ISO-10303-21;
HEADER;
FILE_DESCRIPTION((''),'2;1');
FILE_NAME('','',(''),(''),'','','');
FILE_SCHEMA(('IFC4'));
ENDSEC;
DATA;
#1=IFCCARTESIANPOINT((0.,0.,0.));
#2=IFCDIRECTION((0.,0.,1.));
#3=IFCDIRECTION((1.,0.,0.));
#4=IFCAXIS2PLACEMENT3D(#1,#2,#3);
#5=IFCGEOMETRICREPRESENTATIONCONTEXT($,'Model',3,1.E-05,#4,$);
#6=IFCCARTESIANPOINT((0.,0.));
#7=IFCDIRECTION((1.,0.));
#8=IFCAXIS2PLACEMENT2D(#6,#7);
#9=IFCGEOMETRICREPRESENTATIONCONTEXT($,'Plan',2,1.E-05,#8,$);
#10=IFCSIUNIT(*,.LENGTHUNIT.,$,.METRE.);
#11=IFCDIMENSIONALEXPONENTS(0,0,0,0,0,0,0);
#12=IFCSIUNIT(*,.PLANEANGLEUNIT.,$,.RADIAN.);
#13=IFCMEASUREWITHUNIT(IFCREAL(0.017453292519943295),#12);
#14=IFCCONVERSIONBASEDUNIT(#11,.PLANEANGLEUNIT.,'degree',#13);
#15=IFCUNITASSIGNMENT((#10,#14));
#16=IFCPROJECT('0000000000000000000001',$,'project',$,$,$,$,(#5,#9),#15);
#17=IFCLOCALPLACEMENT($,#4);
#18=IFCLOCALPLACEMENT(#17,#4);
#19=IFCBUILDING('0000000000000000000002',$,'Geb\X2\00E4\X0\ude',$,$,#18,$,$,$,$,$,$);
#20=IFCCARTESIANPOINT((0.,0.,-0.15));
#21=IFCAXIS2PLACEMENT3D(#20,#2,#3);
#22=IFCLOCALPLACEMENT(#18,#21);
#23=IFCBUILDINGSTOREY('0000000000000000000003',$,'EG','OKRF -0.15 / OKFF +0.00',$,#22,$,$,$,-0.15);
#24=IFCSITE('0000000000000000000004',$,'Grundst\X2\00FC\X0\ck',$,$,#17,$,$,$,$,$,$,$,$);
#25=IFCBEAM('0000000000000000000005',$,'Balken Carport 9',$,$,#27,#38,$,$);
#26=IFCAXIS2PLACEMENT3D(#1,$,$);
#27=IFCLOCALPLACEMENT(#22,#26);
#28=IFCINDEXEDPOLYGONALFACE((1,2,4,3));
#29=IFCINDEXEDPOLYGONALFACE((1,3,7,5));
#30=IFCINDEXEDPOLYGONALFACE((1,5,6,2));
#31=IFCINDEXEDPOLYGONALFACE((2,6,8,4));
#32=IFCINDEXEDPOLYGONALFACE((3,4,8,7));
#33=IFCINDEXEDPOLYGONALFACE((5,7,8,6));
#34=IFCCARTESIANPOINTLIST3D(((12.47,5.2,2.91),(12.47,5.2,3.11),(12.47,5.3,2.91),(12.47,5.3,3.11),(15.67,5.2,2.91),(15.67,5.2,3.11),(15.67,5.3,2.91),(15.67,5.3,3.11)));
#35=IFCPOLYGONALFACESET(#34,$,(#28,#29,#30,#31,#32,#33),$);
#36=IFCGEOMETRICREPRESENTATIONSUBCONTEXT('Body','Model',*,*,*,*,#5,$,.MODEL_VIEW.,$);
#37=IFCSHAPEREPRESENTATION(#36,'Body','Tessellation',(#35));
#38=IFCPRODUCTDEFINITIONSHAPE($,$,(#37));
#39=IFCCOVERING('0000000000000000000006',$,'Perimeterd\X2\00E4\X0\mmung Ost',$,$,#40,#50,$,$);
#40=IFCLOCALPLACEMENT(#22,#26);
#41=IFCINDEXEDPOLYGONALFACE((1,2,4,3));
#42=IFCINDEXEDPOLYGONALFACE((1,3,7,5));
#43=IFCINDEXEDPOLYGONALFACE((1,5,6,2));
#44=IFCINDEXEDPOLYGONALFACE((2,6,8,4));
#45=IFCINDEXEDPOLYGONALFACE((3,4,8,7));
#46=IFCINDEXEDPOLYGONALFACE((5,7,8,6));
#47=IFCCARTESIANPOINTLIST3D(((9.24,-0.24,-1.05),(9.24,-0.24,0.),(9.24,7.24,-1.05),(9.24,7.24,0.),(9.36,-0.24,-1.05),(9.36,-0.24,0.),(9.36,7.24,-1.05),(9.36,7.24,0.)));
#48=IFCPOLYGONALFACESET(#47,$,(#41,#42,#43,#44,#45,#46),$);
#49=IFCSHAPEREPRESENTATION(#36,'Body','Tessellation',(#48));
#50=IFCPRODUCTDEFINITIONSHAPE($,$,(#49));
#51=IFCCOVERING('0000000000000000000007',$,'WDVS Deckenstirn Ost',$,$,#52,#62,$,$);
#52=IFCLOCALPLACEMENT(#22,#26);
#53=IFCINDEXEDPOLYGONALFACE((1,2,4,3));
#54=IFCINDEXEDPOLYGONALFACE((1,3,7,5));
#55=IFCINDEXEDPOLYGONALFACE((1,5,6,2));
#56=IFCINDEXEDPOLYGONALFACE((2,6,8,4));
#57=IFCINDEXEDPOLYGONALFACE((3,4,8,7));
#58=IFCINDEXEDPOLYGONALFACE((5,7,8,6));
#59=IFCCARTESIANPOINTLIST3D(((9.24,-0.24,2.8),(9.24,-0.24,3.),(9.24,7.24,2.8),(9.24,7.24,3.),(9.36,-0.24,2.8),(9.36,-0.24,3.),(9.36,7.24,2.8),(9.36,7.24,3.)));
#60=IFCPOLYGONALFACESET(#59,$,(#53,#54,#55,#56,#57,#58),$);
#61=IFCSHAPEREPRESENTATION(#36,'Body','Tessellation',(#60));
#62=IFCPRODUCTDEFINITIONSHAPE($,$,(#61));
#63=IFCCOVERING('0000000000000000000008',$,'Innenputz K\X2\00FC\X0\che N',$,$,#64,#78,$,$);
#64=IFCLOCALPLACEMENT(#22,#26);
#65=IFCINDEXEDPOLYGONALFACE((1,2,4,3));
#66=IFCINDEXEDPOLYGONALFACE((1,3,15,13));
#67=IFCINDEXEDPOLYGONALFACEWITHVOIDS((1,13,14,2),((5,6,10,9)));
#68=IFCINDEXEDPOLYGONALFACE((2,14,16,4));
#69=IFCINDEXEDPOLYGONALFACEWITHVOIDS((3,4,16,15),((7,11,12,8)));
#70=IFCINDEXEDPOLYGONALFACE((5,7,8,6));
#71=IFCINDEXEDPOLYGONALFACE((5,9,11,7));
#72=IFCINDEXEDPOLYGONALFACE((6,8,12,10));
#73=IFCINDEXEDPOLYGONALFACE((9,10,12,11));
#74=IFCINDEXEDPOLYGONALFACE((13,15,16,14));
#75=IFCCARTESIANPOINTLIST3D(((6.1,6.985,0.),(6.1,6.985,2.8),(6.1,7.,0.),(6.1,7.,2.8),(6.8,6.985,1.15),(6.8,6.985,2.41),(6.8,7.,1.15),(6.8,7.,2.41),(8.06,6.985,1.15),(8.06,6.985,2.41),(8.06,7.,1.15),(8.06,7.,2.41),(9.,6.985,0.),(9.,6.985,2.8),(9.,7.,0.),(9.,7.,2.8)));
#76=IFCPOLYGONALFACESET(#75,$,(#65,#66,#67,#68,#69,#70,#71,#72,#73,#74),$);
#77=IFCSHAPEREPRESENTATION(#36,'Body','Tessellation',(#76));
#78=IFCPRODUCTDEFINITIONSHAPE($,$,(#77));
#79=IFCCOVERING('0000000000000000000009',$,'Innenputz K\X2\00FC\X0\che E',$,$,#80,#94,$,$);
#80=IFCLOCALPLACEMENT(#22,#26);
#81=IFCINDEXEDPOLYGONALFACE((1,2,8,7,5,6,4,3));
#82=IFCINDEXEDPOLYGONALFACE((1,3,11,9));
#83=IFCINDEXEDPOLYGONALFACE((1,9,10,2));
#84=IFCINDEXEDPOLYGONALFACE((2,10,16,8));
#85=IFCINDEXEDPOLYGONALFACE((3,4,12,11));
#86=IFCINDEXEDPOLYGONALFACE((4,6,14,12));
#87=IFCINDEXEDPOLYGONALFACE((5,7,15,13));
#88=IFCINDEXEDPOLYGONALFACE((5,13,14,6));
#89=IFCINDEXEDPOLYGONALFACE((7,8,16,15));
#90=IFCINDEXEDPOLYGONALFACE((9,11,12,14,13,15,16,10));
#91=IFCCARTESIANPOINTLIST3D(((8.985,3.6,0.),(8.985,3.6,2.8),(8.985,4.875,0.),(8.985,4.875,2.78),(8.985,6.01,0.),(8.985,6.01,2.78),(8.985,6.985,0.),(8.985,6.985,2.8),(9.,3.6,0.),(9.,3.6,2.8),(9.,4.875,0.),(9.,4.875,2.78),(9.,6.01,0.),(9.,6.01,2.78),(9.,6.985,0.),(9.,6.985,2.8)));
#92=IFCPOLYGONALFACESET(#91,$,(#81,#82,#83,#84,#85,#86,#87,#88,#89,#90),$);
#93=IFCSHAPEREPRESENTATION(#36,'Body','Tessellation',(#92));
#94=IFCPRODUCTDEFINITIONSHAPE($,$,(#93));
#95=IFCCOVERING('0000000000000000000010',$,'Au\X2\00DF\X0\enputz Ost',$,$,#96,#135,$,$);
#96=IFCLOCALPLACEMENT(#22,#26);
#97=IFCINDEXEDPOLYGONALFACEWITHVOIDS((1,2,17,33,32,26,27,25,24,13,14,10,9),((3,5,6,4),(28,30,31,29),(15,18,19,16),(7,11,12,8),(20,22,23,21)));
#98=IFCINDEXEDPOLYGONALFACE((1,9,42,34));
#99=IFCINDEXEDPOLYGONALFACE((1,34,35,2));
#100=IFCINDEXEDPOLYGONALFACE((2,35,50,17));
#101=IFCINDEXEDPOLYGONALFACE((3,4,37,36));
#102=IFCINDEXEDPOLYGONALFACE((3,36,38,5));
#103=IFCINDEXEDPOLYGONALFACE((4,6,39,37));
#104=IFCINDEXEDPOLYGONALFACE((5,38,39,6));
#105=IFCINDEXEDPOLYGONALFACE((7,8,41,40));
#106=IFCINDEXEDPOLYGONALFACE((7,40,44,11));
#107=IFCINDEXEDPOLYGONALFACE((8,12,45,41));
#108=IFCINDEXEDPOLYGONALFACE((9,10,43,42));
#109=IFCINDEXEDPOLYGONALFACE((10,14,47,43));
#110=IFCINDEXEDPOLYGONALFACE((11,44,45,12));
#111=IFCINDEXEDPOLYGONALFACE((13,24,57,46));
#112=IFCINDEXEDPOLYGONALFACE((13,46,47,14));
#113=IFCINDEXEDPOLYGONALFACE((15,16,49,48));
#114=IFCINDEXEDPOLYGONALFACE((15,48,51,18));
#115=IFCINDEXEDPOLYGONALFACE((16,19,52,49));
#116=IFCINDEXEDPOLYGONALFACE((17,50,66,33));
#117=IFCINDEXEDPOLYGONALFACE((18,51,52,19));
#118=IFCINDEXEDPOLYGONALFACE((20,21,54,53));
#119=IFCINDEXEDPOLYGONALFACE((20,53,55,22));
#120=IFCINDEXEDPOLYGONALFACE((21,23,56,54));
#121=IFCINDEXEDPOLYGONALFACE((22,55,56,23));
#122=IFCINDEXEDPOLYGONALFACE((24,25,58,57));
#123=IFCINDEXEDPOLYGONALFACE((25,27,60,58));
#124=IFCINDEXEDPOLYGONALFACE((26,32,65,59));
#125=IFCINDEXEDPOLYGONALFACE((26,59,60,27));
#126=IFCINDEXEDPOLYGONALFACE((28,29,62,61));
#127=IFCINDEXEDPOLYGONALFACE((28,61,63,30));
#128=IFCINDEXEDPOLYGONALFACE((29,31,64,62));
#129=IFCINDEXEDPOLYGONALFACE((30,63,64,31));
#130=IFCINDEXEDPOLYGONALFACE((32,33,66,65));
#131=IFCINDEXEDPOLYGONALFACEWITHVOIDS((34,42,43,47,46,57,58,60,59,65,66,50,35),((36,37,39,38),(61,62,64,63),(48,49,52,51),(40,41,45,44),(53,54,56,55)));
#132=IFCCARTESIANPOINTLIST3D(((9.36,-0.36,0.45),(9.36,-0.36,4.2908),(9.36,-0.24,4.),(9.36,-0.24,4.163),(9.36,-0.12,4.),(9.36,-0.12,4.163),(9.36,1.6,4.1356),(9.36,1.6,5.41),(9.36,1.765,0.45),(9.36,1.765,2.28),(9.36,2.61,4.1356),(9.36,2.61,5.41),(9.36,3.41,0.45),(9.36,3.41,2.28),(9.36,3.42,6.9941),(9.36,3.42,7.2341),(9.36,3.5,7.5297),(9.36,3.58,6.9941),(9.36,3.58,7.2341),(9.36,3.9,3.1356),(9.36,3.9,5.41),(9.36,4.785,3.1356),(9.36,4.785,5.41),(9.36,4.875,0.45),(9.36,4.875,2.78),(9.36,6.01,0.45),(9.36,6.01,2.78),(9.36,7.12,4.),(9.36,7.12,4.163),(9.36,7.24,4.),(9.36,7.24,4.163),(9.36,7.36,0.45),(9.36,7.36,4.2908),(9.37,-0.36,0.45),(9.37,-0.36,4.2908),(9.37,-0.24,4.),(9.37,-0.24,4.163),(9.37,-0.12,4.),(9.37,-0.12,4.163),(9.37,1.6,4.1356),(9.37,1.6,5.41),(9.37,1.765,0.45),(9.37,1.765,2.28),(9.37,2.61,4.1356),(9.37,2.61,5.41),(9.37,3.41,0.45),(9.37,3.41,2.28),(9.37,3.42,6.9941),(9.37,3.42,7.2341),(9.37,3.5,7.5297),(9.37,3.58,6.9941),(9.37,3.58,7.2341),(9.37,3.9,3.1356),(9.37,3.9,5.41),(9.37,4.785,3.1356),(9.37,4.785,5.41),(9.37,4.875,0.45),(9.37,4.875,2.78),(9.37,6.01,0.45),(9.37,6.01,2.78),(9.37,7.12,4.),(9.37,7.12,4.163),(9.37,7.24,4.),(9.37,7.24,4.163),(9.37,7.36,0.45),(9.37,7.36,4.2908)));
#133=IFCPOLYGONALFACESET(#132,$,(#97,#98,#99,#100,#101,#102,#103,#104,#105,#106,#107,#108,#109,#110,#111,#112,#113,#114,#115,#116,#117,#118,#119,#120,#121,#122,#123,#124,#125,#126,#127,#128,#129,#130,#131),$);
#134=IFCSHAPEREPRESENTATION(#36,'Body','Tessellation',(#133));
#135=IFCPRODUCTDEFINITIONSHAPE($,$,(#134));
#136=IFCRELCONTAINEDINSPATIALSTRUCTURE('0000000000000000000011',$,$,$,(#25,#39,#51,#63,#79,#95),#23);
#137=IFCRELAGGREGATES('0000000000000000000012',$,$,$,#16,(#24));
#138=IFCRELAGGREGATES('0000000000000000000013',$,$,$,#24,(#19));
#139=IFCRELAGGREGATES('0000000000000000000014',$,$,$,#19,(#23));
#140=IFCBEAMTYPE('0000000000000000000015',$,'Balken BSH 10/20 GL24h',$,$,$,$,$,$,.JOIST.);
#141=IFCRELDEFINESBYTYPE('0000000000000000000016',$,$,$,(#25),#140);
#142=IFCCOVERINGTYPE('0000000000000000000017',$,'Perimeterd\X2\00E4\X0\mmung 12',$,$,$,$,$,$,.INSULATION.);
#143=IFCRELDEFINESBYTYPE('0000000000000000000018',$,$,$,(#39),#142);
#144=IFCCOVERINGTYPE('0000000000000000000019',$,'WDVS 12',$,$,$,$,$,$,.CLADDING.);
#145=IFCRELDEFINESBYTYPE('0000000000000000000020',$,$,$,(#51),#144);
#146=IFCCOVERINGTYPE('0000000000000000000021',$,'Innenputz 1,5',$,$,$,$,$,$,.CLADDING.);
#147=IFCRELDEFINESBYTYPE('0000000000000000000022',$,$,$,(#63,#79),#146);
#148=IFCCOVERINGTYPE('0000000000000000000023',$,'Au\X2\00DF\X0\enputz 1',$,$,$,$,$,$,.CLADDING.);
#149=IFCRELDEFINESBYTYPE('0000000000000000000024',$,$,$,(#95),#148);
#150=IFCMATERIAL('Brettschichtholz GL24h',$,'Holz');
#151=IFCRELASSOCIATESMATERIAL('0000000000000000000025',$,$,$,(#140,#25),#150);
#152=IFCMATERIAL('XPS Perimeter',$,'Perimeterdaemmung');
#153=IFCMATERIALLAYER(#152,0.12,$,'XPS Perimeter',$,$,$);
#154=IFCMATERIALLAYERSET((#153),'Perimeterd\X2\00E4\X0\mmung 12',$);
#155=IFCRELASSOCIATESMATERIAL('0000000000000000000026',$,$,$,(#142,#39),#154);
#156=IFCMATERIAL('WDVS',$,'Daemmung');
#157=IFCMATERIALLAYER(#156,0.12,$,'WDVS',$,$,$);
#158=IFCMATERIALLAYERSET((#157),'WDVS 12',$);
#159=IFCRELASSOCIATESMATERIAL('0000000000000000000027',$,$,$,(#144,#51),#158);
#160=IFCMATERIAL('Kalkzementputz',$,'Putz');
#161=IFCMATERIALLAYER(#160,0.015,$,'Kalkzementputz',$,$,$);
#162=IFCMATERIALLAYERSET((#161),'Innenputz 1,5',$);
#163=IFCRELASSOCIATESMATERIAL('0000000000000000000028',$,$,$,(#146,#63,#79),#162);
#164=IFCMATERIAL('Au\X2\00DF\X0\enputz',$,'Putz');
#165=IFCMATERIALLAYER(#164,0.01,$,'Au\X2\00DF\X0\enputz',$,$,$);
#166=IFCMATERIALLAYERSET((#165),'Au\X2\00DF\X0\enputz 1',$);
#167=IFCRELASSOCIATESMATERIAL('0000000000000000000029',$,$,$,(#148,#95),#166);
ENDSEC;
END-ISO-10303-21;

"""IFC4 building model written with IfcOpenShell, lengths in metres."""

from ifc_helpers import new_model, entity, si_unit, converted_unit, frame, origin_with_axes, origin_2d_with_axis, place, context, subcontext, project, spatial, indexed_curve, rectangle, outline, extrude, clip, halfspace, material, layer, layer_set, layer_usage, material_profile, profile_set, profile_usage, type_object, element, save


model = new_model("IFC4")

# Units and contexts
model_context = context("Model", 3, precision=1e-05, world=origin_with_axes())
plan_context = context("Plan", 2, precision=1e-05, world=origin_2d_with_axis())
body_context = subcontext(model_context, "Body", "Model", "MODEL_VIEW")
ifc_project = project(units=[si_unit("LENGTHUNIT", "METRE"), converted_unit("PLANEANGLEUNIT", "degree", entity("IfcReal", 0.017453292519943295), si_unit("PLANEANGLEUNIT", "RADIAN"), dimensions=[0, 0, 0, 0, 0, 0, 0])], contexts=[model_context, plan_context])

# Site, building, storey
site_placement = place(None, origin_with_axes())
site = spatial("IfcSite", under=ifc_project, at=site_placement, Name="Grundstück")
building_placement = place(site_placement, origin_with_axes())
building = spatial("IfcBuilding", under=site, at=building_placement, Name="Gebäude")
storey_placement = place(building_placement, frame((0.0, 0.0, -0.15), z_axis=(0.0, 0.0, 1.0), x_axis=(1.0, 0.0, 0.0)))
storey = spatial("IfcBuildingStorey", under=building, at=storey_placement, Name="EG", Description="OKRF -0.15 / OKFF +0.00", Elevation=-0.15)

# Beam
ifc_material_1 = material(Name="Brettschichtholz GL24h", Category="Holz")
ifc_material_profile_1 = material_profile(ifc_material_1, rectangle(XDim=0.1, YDim=0.2))
ifc_profile_set_1 = profile_set([ifc_material_profile_1], Name="Balken BSH 10/20 GL24h")
ifc_profile_usage_1 = profile_usage(ifc_profile_set_1)
beam_type_1 = type_object("IfcBeamType", Name="Balken BSH 10/20 GL24h", PredefinedType="JOIST", material=ifc_profile_set_1)
beam_1_placement = place(storey_placement, frame((12.47, 5.25, 3.01), z_axis=(1.0, 0.0, 0.0), x_axis=(0.0, 1.0, 0.0)))
element("IfcBeam", 1, at=beam_1_placement, inside=storey, type_object=beam_type_1, material=ifc_profile_usage_1, Name="Balken Carport 9", context=body_context, shape_type="SweptSolid", body=[
    extrude(rectangle(XDim=0.1, YDim=0.2), origin_with_axes(), (0.0, 0.0, 1.0), 3.2),
])

# Coverings
ifc_material_2 = material(Name="XPS Perimeter", Category="Perimeterdaemmung")
ifc_layer_1 = layer(ifc_material_2, 0.12, Name="XPS Perimeter")
ifc_layer_set_1 = layer_set([ifc_layer_1], Name="Perimeterdämmung 12")
ifc_layer_usage_1 = layer_usage(ifc_layer_set_1, "AXIS2", "POSITIVE", 0.0)
covering_type_1 = type_object("IfcCoveringType", Name="Perimeterdämmung 12", PredefinedType="INSULATION", material=ifc_layer_set_1)
covering_1_placement = place(storey_placement, frame((9.24, 7.24, -1.05), z_axis=(0.0, 0.0, 1.0), x_axis=(0.0, -1.0, 0.0)))
element("IfcCovering", 2, at=covering_1_placement, inside=storey, type_object=covering_type_1, material=ifc_layer_usage_1, Name="Perimeterdämmung Ost", context=body_context, shape_type="SweptSolid", body=[
    extrude(outline(indexed_curve([(0.0, 0.0), (0.0, 0.12), (7.48, 0.12), (7.48, 0.0), (0.0, 0.0)], self_intersect=False)), origin_with_axes(), (0.0, 0.0, 1.0), 1.05),
])
ifc_material_3 = material(Name="WDVS", Category="Daemmung")
ifc_layer_2 = layer(ifc_material_3, 0.12, Name="WDVS")
ifc_layer_set_2 = layer_set([ifc_layer_2], Name="WDVS 12")
ifc_layer_usage_2 = layer_usage(ifc_layer_set_2, "AXIS2", "POSITIVE", 0.0)
covering_type_2 = type_object("IfcCoveringType", Name="WDVS 12", PredefinedType="CLADDING", material=ifc_layer_set_2)
covering_2_placement = place(storey_placement, frame((9.24, 7.24, 2.8), z_axis=(0.0, 0.0, 1.0), x_axis=(0.0, -1.0, 0.0)))
element("IfcCovering", 3, at=covering_2_placement, inside=storey, type_object=covering_type_2, material=ifc_layer_usage_2, Name="WDVS Deckenstirn Ost", context=body_context, shape_type="SweptSolid", body=[
    extrude(outline(indexed_curve([(0.0, 0.0), (0.0, 0.12), (7.48, 0.12), (7.48, 0.0), (0.0, 0.0)], self_intersect=False)), origin_with_axes(), (0.0, 0.0, 1.0), 0.2),
])
ifc_material_4 = material(Name="Kalkzementputz", Category="Putz")
ifc_layer_3 = layer(ifc_material_4, 0.015, Name="Kalkzementputz")
ifc_layer_set_3 = layer_set([ifc_layer_3], Name="Innenputz 1,5")
covering_type_3 = type_object("IfcCoveringType", Name="Innenputz 1,5", PredefinedType="CLADDING", material=ifc_layer_set_3)

# Coverings, openings
ifc_layer_usage_3 = layer_usage(ifc_layer_set_3, "AXIS2", "POSITIVE", 0.0)
covering_3_placement = place(storey_placement, frame((9.0, 7.0, 0.0), z_axis=(0.0, 0.0, 1.0), x_axis=(-1.0, 0.0, 0.0)))
covering_3 = element("IfcCovering", 4, at=covering_3_placement, inside=storey, type_object=covering_type_3, material=ifc_layer_usage_3, Name="Innenputz Küche N", context=body_context, shape_type="SweptSolid", body=[
    extrude(outline(indexed_curve([(0.0, 0.0), (0.0, 0.015), (2.9, 0.015), (2.9, 0.0), (0.0, 0.0)], self_intersect=False)), origin_with_axes(), (0.0, 0.0, 1.0), 2.8),
])
opening_1_placement = place(covering_3_placement, frame((0.94, -0.05, 1.15), z_axis=(0.0, 0.0, 1.0), x_axis=(1.0, 0.0, 0.0)))
element("IfcOpeningElement", 5, at=opening_1_placement, cuts=covering_3, context=body_context, shape_type="SweptSolid", body=[
    extrude(outline(indexed_curve([(0.0, 0.0), (0.0, 0.115), (1.26, 0.115), (1.26, 0.0), (0.0, 0.0)], self_intersect=False)), origin_with_axes(), (0.0, 0.0, 1.0), 1.26),
])
ifc_layer_usage_4 = layer_usage(ifc_layer_set_3, "AXIS2", "POSITIVE", 0.0)
covering_4_placement = place(storey_placement, frame((9.0, 3.6, 0.0), z_axis=(0.0, 0.0, 1.0), x_axis=(0.0, 1.0, 0.0)))
covering_4 = element("IfcCovering", 6, at=covering_4_placement, inside=storey, type_object=covering_type_3, material=ifc_layer_usage_4, Name="Innenputz Küche E", context=body_context, shape_type="SweptSolid", body=[
    extrude(outline(indexed_curve([(0.0, 0.0), (0.0, 0.015), (3.385, 0.015), (3.385, 0.0), (0.0, 0.0)], self_intersect=False)), origin_with_axes(), (0.0, 0.0, 1.0), 2.8),
])
opening_2_placement = place(covering_4_placement, frame((1.275, -0.05, 0.0), z_axis=(0.0, 0.0, 1.0), x_axis=(1.0, 0.0, 0.0)))
element("IfcOpeningElement", 7, at=opening_2_placement, cuts=covering_4, context=body_context, shape_type="SweptSolid", body=[
    extrude(outline(indexed_curve([(0.0, 0.0), (0.0, 0.115), (1.135, 0.115), (1.135, 0.0), (0.0, 0.0)], self_intersect=False)), origin_with_axes(), (0.0, 0.0, 1.0), 2.78),
])

# Shared definitions
ifc_material_5 = material(Name="Außenputz", Category="Putz")
ifc_layer_4 = layer(ifc_material_5, 0.01, Name="Außenputz")
ifc_layer_set_4 = layer_set([ifc_layer_4], Name="Außenputz 1")
covering_type_4 = type_object("IfcCoveringType", Name="Außenputz 1", PredefinedType="CLADDING", material=ifc_layer_set_4)

# Covering, openings
ifc_layer_usage_5 = layer_usage(ifc_layer_set_4, "AXIS2", "POSITIVE", 0.0)
covering_5_placement = place(storey_placement, frame((9.36, 7.36, 0.45), z_axis=(0.0, 0.0, 1.0), x_axis=(0.0, -1.0, 0.0)))
covering_5 = element("IfcCovering", 8, at=covering_5_placement, inside=storey, type_object=covering_type_4, material=ifc_layer_usage_5, Name="Außenputz Ost", context=body_context, shape_type="Clipping", body=[
    clip(clip(extrude(outline(indexed_curve([(0.0, 0.0), (0.0, 0.01), (7.72, 0.01), (7.72, 0.0), (0.0, 0.0)], self_intersect=False)), origin_with_axes(), (0.0, 0.0, 1.0), 7.4797), halfspace(frame((7.6, -9.36, 3.9414), z_axis=(0.642788, 0.0, 0.766044), x_axis=(0.0, -1.0, 0.0)), False)), halfspace(frame((0.12, -9.36, 3.9414), z_axis=(-0.642788, 0.0, 0.766044), x_axis=(0.0, 1.0, 0.0)), False)),
])
opening_3_placement = place(covering_5_placement, frame((1.35, -0.05, 0.0), z_axis=(0.0, 0.0, 1.0), x_axis=(1.0, 0.0, 0.0)))
element("IfcOpeningElement", 9, at=opening_3_placement, cuts=covering_5, context=body_context, shape_type="SweptSolid", body=[
    extrude(outline(indexed_curve([(0.0, 0.0), (0.0, 0.11), (1.135, 0.11), (1.135, 0.0), (0.0, 0.0)], self_intersect=False)), origin_with_axes(), (0.0, 0.0, 1.0), 2.33),
])
opening_4_placement = place(covering_5_placement, frame((3.95, -0.05, 0.0), z_axis=(0.0, 0.0, 1.0), x_axis=(1.0, 0.0, 0.0)))
element("IfcOpeningElement", 10, at=opening_4_placement, cuts=covering_5, context=body_context, shape_type="SweptSolid", body=[
    extrude(outline(indexed_curve([(0.0, 0.0), (0.0, 0.11), (1.645, 0.11), (1.645, 0.0), (0.0, 0.0)], self_intersect=False)), origin_with_axes(), (0.0, 0.0, 1.0), 1.83),
])
opening_5_placement = place(covering_5_placement, frame((4.75, -0.05, 3.6856), z_axis=(0.0, 0.0, 1.0), x_axis=(1.0, 0.0, 0.0)))
element("IfcOpeningElement", 11, at=opening_5_placement, cuts=covering_5, context=body_context, shape_type="SweptSolid", body=[
    extrude(outline(indexed_curve([(0.0, 0.0), (0.0, 0.11), (1.01, 0.11), (1.01, 0.0), (0.0, 0.0)], self_intersect=False)), origin_with_axes(), (0.0, 0.0, 1.0), 1.2744),
])
opening_6_placement = place(covering_5_placement, frame((2.575, -0.05, 2.6856), z_axis=(0.0, 0.0, 1.0), x_axis=(1.0, 0.0, 0.0)))
element("IfcOpeningElement", 12, at=opening_6_placement, cuts=covering_5, context=body_context, shape_type="SweptSolid", body=[
    extrude(outline(indexed_curve([(0.0, 0.0), (0.0, 0.11), (0.885, 0.11), (0.885, 0.0), (0.0, 0.0)], self_intersect=False)), origin_with_axes(), (0.0, 0.0, 1.0), 2.2744),
])
opening_7_placement = place(covering_5_placement, frame((7.48, -0.05, 3.55), z_axis=(0.0, 0.0, 1.0), x_axis=(1.0, 0.0, 0.0)))
element("IfcOpeningElement", 13, at=opening_7_placement, cuts=covering_5, context=body_context, shape_type="SweptSolid", body=[
    extrude(outline(indexed_curve([(0.0, 0.0), (0.0, 0.11), (0.12, 0.11), (0.12, 0.0), (0.0, 0.0)], self_intersect=False)), origin_with_axes(), (0.0, 0.0, 1.0), 0.163),
])
opening_8_placement = place(covering_5_placement, frame((0.12, -0.05, 3.55), z_axis=(0.0, 0.0, 1.0), x_axis=(1.0, 0.0, 0.0)))
element("IfcOpeningElement", 14, at=opening_8_placement, cuts=covering_5, context=body_context, shape_type="SweptSolid", body=[
    extrude(outline(indexed_curve([(0.0, 0.0), (0.0, 0.11), (0.12, 0.11), (0.12, 0.0), (0.0, 0.0)], self_intersect=False)), origin_with_axes(), (0.0, 0.0, 1.0), 0.163),
])
opening_9_placement = place(covering_5_placement, frame((3.78, -0.05, 6.5441), z_axis=(0.0, 0.0, 1.0), x_axis=(1.0, 0.0, 0.0)))
element("IfcOpeningElement", 15, at=opening_9_placement, cuts=covering_5, context=body_context, shape_type="SweptSolid", body=[
    extrude(outline(indexed_curve([(0.0, 0.0), (0.0, 0.11), (0.16, 0.11), (0.16, 0.0), (0.0, 0.0)], self_intersect=False)), origin_with_axes(), (0.0, 0.0, 1.0), 0.24),
])

save(model, "model.ifc")
